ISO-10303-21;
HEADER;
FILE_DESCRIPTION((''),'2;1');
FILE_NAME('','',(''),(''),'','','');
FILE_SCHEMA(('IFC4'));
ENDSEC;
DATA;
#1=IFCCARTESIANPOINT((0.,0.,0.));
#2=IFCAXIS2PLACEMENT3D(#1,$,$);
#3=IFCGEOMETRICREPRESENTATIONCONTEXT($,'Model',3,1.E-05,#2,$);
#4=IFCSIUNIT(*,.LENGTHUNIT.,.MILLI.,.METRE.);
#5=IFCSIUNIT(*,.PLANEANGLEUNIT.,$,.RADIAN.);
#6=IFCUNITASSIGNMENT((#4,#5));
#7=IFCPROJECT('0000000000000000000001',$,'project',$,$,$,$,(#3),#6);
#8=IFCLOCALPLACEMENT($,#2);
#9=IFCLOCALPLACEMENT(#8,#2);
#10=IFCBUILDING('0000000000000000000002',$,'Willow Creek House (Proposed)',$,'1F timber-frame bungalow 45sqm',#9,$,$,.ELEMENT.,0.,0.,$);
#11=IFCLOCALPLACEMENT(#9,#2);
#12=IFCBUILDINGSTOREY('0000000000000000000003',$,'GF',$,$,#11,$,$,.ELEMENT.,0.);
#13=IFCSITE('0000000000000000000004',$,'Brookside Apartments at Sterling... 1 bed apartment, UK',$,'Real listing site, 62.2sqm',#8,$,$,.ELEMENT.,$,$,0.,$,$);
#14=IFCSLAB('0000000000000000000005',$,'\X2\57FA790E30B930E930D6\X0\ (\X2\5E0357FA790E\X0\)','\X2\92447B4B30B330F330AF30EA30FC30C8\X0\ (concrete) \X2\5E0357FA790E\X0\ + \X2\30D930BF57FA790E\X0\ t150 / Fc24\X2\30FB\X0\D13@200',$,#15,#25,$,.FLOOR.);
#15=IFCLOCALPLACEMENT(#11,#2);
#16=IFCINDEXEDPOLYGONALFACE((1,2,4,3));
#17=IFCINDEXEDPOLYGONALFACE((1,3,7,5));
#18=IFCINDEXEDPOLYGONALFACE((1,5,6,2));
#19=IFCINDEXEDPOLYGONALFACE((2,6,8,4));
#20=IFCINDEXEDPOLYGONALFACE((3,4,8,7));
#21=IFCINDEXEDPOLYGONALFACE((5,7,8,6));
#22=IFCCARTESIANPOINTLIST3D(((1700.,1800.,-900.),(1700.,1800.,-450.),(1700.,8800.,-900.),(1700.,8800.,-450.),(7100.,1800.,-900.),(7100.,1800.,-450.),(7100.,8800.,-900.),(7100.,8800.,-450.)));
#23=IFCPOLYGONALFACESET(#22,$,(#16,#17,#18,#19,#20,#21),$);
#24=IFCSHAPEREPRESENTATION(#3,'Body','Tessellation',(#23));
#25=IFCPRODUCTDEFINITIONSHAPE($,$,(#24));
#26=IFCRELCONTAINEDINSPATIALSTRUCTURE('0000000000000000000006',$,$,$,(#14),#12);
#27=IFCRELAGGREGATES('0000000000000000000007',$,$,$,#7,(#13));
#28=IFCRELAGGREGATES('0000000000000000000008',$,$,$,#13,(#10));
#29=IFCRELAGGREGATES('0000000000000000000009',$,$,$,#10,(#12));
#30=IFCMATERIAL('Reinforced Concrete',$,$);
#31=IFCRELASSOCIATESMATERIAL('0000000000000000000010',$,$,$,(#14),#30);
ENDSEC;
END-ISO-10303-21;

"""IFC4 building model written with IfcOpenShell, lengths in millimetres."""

from ifc_helpers import new_model, si_unit, frame, frame_2d, origin, place, context, project, spatial, rectangle, extrude, material, element, save


model = new_model("IFC4")

# Units and contexts
model_context = context("Model", 3, precision=1e-05, world=origin())
ifc_project = project(units=[si_unit("LENGTHUNIT", "METRE", prefix="MILLI"), si_unit("PLANEANGLEUNIT", "RADIAN")], contexts=[model_context])

# Site, building, storey
site_placement = place(None, origin())
site = spatial("IfcSite", under=ifc_project, at=site_placement, Name="Brookside Apartments at Sterling... 1 bed apartment, UK", ObjectType="Real listing site, 62.2sqm", CompositionType="ELEMENT", RefElevation=0.0)
building_placement = place(site_placement, origin())
building = spatial("IfcBuilding", under=site, at=building_placement, Name="Willow Creek House (Proposed)", ObjectType="1F timber-frame bungalow 45sqm", CompositionType="ELEMENT", ElevationOfRefHeight=0.0, ElevationOfTerrain=0.0)
storey_placement = place(building_placement, origin())
storey = spatial("IfcBuildingStorey", under=building, at=storey_placement, Name="GF", CompositionType="ELEMENT", Elevation=0.0)

# Slab
ifc_material_1 = material(Name="Reinforced Concrete")
slab_1_placement = place(storey_placement, frame((850.0, 900.0, -450.0)))
element("IfcSlab", 1, at=slab_1_placement, inside=storey, material=ifc_material_1, Name="基礎スラブ (布基礎)", Description="鉄筋コンクリート (concrete) 布基礎 + ベタ基礎 t150 / Fc24・D13@200", PredefinedType="FLOOR", context=model_context, shape_type="SweptSolid", body=[
    extrude(rectangle(XDim=5400.0, YDim=7000.0, at=frame_2d((2700.0, 3500.0))), frame((850.0, 900.0, -450.0)), (0.0, 0.0, 1.0), 450.0),
])

save(model, "model.ifc")
